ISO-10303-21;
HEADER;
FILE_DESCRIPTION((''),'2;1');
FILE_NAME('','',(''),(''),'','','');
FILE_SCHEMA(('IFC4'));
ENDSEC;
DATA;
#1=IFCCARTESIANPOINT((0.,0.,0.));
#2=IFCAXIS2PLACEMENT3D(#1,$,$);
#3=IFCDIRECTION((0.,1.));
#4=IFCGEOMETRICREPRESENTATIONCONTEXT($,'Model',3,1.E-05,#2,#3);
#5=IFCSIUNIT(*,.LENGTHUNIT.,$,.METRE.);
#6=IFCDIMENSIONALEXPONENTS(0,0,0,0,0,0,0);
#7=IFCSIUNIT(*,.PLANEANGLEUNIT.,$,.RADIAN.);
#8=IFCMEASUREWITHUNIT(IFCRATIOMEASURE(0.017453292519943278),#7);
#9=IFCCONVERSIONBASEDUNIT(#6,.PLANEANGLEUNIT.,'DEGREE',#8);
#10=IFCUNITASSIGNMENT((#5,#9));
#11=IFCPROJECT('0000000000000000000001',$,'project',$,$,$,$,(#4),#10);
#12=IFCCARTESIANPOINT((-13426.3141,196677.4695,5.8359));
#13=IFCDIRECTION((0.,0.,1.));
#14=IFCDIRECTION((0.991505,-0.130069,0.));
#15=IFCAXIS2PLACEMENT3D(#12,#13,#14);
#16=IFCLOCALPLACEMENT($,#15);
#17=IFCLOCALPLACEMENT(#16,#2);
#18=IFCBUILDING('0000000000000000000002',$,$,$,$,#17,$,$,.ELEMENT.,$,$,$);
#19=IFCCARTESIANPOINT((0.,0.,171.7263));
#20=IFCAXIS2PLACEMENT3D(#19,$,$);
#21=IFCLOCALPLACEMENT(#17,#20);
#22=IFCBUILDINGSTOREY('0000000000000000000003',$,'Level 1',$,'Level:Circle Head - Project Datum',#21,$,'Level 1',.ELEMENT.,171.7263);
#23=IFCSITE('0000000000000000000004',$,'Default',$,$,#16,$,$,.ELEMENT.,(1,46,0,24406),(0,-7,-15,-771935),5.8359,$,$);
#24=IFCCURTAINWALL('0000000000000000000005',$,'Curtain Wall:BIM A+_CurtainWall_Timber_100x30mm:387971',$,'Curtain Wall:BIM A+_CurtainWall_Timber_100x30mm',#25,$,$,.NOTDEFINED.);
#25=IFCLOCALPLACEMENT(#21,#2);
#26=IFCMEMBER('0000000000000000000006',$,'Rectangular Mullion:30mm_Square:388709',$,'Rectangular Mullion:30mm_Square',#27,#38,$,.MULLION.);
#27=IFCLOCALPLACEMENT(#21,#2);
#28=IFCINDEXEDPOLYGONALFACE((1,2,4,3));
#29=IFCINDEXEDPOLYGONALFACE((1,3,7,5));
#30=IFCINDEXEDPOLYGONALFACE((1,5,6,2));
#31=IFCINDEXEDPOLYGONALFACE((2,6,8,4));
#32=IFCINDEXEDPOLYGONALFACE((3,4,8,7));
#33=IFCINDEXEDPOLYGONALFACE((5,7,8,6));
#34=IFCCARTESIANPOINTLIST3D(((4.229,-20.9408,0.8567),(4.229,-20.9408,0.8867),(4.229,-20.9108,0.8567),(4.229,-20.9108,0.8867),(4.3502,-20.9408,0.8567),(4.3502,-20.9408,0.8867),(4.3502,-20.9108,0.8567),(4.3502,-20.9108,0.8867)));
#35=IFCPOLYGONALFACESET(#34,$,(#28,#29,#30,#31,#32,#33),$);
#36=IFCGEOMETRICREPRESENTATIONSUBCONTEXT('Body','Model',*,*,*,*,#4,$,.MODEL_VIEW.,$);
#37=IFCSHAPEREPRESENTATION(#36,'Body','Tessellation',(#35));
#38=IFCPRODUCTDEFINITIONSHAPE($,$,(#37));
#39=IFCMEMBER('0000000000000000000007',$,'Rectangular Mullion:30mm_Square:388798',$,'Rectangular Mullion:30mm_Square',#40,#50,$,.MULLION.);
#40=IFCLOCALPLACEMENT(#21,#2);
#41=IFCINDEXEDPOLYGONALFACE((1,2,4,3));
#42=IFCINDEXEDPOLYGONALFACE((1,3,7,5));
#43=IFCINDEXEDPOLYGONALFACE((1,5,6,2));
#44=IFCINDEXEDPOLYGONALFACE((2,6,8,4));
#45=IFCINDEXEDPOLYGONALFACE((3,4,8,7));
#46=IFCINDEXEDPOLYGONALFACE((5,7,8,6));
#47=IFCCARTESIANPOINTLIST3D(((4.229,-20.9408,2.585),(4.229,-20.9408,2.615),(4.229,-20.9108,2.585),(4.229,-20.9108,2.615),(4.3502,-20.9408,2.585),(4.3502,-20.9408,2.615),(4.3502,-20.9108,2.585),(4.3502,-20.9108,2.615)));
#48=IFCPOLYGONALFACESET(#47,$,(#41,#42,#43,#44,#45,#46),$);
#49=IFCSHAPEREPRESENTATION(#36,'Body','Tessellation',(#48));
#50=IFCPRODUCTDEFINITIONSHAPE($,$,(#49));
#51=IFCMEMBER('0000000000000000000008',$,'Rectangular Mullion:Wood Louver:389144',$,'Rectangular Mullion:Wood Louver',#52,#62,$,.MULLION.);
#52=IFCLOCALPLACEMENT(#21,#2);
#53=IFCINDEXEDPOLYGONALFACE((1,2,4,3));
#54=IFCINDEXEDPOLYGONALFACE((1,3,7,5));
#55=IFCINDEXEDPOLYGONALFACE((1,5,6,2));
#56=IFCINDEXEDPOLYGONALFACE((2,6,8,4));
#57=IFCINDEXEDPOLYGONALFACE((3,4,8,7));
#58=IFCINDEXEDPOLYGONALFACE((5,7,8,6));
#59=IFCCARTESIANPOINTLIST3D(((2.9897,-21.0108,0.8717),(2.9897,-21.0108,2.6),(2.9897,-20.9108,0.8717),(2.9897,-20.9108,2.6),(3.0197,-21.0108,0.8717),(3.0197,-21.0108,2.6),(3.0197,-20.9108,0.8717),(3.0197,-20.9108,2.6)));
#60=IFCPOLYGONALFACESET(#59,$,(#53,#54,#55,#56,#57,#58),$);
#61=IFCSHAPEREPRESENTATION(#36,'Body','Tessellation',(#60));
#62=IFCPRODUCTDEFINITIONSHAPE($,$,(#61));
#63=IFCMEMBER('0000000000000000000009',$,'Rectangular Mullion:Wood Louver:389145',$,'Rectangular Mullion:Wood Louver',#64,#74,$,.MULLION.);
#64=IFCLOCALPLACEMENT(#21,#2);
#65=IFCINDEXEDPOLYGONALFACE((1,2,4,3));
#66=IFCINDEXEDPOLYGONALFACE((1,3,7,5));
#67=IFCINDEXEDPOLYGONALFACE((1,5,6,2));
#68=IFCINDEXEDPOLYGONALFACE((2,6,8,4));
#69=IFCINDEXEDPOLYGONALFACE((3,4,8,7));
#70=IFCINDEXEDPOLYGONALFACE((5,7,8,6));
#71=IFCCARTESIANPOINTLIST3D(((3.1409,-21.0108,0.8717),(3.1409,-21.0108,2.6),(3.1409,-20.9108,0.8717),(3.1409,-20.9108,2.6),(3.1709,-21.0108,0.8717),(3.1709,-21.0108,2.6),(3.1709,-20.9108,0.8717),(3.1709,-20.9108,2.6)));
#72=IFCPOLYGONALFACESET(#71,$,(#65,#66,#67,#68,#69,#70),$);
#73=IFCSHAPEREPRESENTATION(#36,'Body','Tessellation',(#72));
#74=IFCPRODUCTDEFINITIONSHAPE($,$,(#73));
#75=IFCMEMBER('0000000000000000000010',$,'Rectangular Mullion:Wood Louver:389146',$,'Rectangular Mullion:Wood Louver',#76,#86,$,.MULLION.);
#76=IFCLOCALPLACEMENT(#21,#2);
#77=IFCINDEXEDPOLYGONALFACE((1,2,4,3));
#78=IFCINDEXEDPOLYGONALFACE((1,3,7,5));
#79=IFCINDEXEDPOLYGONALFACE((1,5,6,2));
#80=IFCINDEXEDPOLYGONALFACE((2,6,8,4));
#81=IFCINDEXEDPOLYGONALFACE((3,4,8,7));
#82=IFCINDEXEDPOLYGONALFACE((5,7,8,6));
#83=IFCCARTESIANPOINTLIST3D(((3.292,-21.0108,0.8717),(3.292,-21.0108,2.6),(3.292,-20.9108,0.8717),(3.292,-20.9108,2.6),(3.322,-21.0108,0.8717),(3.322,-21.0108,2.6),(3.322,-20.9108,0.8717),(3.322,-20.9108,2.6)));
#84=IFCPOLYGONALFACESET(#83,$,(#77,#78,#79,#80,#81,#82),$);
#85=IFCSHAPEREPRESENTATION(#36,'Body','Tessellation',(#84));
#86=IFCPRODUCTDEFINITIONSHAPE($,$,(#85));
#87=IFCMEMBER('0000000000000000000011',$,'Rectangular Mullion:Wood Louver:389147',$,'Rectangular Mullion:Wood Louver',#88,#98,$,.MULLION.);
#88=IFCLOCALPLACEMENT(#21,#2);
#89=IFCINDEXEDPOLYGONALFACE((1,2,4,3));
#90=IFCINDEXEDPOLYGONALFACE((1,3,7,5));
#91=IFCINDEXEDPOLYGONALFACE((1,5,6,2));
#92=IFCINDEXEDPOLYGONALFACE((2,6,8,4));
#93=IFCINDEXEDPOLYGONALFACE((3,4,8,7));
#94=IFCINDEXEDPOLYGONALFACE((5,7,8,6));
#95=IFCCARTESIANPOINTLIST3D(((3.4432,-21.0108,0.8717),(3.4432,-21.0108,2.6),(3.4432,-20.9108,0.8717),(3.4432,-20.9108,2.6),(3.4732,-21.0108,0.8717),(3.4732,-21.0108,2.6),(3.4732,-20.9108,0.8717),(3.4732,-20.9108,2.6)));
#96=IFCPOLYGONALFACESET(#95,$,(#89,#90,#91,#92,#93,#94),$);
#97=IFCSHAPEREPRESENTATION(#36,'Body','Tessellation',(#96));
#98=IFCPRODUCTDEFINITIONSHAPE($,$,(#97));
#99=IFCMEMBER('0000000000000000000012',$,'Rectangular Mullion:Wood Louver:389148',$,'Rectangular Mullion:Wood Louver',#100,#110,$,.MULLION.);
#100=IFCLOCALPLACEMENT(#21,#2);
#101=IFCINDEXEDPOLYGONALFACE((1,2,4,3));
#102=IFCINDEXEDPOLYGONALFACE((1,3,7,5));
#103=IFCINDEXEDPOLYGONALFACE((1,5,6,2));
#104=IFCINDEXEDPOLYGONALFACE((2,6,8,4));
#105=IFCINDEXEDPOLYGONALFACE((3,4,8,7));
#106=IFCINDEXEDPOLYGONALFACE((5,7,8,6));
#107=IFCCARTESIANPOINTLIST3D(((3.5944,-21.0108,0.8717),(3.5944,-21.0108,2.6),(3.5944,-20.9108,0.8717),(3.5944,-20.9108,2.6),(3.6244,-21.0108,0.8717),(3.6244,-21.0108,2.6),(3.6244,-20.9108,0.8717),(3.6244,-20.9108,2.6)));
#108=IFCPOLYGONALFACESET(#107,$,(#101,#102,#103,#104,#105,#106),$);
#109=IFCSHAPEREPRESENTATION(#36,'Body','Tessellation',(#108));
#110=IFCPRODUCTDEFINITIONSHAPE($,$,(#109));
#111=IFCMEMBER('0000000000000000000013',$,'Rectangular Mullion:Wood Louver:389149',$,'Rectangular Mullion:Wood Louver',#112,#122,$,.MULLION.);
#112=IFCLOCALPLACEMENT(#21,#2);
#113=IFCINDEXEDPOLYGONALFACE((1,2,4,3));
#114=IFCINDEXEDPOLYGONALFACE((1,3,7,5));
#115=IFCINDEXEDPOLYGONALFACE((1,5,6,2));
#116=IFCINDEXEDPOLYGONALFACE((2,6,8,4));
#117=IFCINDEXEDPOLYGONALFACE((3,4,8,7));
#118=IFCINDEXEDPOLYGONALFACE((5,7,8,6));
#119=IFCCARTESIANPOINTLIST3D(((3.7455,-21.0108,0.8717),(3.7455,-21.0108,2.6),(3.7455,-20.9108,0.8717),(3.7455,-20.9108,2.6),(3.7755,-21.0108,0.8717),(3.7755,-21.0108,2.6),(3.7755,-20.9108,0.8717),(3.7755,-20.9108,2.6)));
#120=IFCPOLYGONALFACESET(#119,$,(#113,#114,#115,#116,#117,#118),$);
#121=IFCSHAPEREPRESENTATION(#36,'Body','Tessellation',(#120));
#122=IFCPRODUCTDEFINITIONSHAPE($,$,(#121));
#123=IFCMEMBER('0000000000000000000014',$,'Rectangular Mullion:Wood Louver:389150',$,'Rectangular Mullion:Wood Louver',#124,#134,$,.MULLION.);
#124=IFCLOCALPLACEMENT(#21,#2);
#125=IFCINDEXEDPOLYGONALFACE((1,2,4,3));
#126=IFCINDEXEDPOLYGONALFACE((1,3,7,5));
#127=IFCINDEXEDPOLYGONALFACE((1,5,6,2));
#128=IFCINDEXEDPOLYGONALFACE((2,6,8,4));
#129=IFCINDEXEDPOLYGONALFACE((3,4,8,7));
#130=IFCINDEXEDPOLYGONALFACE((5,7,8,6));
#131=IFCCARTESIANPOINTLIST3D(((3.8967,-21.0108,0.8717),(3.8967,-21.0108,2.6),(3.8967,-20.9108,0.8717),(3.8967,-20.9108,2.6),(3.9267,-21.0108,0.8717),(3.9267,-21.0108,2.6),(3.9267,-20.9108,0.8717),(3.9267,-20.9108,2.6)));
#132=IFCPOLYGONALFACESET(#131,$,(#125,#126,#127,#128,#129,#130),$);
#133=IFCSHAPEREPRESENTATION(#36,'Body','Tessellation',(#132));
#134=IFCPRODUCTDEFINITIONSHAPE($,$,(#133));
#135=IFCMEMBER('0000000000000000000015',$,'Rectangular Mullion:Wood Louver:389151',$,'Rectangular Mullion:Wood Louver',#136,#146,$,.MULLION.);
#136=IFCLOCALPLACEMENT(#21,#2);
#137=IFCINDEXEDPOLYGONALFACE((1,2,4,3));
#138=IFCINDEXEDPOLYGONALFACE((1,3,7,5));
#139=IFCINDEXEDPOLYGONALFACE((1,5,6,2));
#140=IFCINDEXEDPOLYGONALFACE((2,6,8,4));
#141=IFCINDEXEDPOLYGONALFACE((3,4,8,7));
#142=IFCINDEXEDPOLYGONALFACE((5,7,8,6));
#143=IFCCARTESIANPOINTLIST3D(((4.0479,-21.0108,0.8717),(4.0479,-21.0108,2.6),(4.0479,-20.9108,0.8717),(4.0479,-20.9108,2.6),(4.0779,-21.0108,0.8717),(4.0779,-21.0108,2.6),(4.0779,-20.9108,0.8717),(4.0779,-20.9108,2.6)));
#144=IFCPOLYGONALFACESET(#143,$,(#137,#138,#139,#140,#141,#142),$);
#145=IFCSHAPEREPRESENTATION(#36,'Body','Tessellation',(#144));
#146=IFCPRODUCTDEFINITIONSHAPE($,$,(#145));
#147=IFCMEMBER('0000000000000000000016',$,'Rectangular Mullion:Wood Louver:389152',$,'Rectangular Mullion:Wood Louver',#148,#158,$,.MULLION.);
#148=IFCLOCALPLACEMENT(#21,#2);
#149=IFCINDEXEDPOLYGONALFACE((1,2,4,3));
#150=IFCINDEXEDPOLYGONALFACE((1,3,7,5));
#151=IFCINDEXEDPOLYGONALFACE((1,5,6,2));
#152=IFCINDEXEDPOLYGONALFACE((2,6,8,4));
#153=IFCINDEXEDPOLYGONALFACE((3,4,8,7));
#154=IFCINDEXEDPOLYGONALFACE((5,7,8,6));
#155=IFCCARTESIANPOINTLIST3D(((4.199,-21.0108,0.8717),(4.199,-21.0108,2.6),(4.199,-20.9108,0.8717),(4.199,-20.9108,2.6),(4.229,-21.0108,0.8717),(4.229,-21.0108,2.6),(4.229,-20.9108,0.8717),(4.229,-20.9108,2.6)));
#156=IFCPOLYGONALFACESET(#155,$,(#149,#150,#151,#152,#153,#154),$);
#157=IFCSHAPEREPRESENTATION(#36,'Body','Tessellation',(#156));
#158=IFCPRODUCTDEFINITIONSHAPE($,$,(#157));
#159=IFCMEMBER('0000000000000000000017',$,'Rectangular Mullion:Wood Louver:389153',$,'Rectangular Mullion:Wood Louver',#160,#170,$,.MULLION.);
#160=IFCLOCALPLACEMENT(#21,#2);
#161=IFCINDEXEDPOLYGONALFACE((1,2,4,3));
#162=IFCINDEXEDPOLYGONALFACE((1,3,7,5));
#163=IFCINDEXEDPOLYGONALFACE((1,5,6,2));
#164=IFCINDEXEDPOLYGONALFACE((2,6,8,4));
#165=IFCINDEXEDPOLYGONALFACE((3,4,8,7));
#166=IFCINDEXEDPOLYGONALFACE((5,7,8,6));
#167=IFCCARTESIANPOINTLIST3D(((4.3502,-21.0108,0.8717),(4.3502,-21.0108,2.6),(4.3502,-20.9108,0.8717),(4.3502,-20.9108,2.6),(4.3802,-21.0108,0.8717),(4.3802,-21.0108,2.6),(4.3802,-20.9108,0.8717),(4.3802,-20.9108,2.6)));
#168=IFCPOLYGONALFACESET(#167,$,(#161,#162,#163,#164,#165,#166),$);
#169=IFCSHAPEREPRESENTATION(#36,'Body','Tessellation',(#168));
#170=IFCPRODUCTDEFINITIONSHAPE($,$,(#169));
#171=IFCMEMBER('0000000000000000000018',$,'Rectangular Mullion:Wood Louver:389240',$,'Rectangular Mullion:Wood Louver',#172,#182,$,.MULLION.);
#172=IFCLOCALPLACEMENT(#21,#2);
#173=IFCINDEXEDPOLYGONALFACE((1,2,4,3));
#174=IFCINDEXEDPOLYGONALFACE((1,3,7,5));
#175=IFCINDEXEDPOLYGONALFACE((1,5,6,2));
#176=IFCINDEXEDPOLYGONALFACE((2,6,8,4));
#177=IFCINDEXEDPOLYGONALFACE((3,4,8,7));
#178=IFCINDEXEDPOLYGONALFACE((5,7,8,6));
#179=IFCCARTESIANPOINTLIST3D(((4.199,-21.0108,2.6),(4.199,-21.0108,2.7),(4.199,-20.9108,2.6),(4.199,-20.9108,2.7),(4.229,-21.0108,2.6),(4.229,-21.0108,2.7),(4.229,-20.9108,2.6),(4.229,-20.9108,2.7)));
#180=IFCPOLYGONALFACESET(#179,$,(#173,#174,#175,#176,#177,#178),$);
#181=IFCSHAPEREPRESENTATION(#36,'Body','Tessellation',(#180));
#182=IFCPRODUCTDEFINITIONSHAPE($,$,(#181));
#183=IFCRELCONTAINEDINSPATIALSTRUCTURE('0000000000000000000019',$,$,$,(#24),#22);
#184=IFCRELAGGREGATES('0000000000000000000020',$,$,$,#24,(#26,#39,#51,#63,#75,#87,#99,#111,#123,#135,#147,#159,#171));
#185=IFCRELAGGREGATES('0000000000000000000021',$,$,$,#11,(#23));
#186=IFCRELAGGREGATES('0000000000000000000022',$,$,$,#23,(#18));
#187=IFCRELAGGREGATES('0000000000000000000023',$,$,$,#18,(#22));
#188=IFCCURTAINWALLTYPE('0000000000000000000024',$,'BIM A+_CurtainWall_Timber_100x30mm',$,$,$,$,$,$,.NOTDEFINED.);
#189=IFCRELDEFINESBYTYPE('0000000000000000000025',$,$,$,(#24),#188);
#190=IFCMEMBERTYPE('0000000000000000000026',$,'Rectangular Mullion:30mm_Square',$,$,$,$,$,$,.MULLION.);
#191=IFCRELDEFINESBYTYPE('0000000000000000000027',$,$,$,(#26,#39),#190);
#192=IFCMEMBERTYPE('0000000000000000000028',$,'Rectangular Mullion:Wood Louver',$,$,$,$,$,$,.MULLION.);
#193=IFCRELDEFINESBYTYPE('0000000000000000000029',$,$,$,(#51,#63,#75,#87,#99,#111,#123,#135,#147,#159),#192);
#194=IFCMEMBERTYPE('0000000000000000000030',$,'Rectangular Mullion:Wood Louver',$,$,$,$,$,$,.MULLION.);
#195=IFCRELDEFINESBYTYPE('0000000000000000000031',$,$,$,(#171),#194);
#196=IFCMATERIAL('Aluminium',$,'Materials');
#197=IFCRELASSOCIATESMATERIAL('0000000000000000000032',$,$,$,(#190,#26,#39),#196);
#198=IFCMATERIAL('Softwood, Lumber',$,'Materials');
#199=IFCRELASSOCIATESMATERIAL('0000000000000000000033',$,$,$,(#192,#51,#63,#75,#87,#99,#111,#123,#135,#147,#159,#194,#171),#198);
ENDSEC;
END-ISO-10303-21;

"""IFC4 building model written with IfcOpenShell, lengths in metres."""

from ifc_helpers import new_model, entity, si_unit, converted_unit, direction, frame, origin, place, context, subcontext, project, spatial, indexed_curve, outline, extrude, source, transform, mapped, material, type_object, type_shapes, element, aggregate, save


model = new_model("IFC4")

# Units and contexts
model_context = context("Model", 3, precision=1e-05, world=origin(), true_north=direction((0.0, 1.0)))
body_context = subcontext(model_context, "Body", "Model", "MODEL_VIEW")
ifc_project = project(units=[si_unit("LENGTHUNIT", "METRE"), converted_unit("PLANEANGLEUNIT", "DEGREE", entity("IfcRatioMeasure", 0.017453292519943278), si_unit("PLANEANGLEUNIT", "RADIAN"), dimensions=[0, 0, 0, 0, 0, 0, 0])], contexts=[model_context])

# Site, building, storey
site_placement = place(None, frame((-13426.3141, 196677.4695, 5.8359), z_axis=(0.0, 0.0, 1.0), x_axis=(0.991505, -0.130069, 0.0)))
site = spatial("IfcSite", under=ifc_project, at=site_placement, Name="Default", CompositionType="ELEMENT", RefLatitude=(1, 46, 0, 24406), RefLongitude=(0, -7, -15, -771935), RefElevation=5.8359)
building_placement = place(site_placement, origin())
building = spatial("IfcBuilding", under=site, at=building_placement, CompositionType="ELEMENT")
storey_placement = place(building_placement, frame((0.0, 0.0, 171.7263)))
storey = spatial("IfcBuildingStorey", under=building, at=storey_placement, Name="Level 1", ObjectType="Level:Circle Head - Project Datum", LongName="Level 1", CompositionType="ELEMENT", Elevation=171.7263)

# Curtain wall, members
ifc_material_1 = material(Name="Aluminium", Category="Materials")
curtain_wall_type_1 = type_object("IfcCurtainWallType", Name="BIM A+_CurtainWall_Timber_100x30mm", PredefinedType="NOTDEFINED")
curtain_wall_1_placement = place(storey_placement, frame((0.0, 0.0, -171.7263)))
curtain_wall_1 = element("IfcCurtainWall", 1, at=curtain_wall_1_placement, inside=storey, type_object=curtain_wall_type_1, Name="Curtain Wall:BIM A+_CurtainWall_Timber_100x30mm:387971", ObjectType="Curtain Wall:BIM A+_CurtainWall_Timber_100x30mm", PredefinedType="NOTDEFINED")
ifc_material_2 = material(Name="Softwood, Lumber", Category="Materials")
member_type_1 = type_object("IfcMemberType", Name="Rectangular Mullion:30mm_Square", PredefinedType="MULLION", material=ifc_material_1)
shared_shape_1 = source(origin(), body_context, "Body", "SweptSolid", [
    extrude(outline(indexed_curve([(-0.015, -0.015), (0.015, -0.015), (0.015, 0.015), (-0.015, 0.015), (-0.015, -0.015)], self_intersect=False)), frame((0.0, 0.0, -0.1212), z_axis=(0.0, 0.0, 1.0), x_axis=(0.0, -1.0, 0.0)), (0.0, 0.0, 1.0), 0.1212),
])
type_shapes(member_type_1, [shared_shape_1])
member_1_placement = place(curtain_wall_1_placement, frame((4.3502, -20.9258, 172.598), z_axis=(1.0, 0.0, 0.0), x_axis=(0.0, 0.0, 1.0)))
member_1 = element("IfcMember", 2, at=member_1_placement, type_object=member_type_1, material=ifc_material_1, Name="Rectangular Mullion:30mm_Square:388709", ObjectType="Rectangular Mullion:30mm_Square", PredefinedType="MULLION", context=body_context, shape_type="MappedRepresentation", body=[
    mapped(shared_shape_1, transform((0.0, 0.0, 0.0), scale=1.0)),
])
member_2_placement = place(curtain_wall_1_placement, frame((4.3502, -20.9258, 174.3263), z_axis=(1.0, 0.0, 0.0), x_axis=(0.0, 0.0, 1.0)))
member_2 = element("IfcMember", 3, at=member_2_placement, type_object=member_type_1, material=ifc_material_1, Name="Rectangular Mullion:30mm_Square:388798", ObjectType="Rectangular Mullion:30mm_Square", PredefinedType="MULLION", context=body_context, shape_type="MappedRepresentation", body=[
    mapped(shared_shape_1, transform((0.0, 0.0, 0.0), scale=1.0)),
])
member_type_2 = type_object("IfcMemberType", Name="Rectangular Mullion:Wood Louver", PredefinedType="MULLION", material=ifc_material_2)
shared_shape_2 = source(origin(), body_context, "Body", "SweptSolid", [
    extrude(outline(indexed_curve([(-0.05, -0.015), (0.05, -0.015), (0.05, 0.015), (-0.05, 0.015), (-0.05, -0.015)], self_intersect=False)), frame((0.0, 0.035, -1.7283), z_axis=(0.0, 0.0, 1.0), x_axis=(0.0, -1.0, 0.0)), (0.0, 0.0, 1.0), 1.7283),
])
type_shapes(member_type_2, [shared_shape_2])
member_3_placement = place(curtain_wall_1_placement, frame((3.0047, -20.9258, 172.598), z_axis=(0.0, 0.0, -1.0), x_axis=(1.0, 0.0, 0.0)))
member_3 = element("IfcMember", 4, at=member_3_placement, type_object=member_type_2, material=ifc_material_2, Name="Rectangular Mullion:Wood Louver:389144", ObjectType="Rectangular Mullion:Wood Louver", PredefinedType="MULLION", context=body_context, shape_type="MappedRepresentation", body=[
    mapped(shared_shape_2, transform((0.0, 0.0, 0.0), scale=1.0)),
])
member_4_placement = place(curtain_wall_1_placement, frame((3.1559, -20.9258, 172.598), z_axis=(0.0, 0.0, -1.0), x_axis=(1.0, 0.0, 0.0)))
member_4 = element("IfcMember", 5, at=member_4_placement, type_object=member_type_2, material=ifc_material_2, Name="Rectangular Mullion:Wood Louver:389145", ObjectType="Rectangular Mullion:Wood Louver", PredefinedType="MULLION", context=body_context, shape_type="MappedRepresentation", body=[
    mapped(shared_shape_2, transform((0.0, 0.0, 0.0), scale=1.0)),
])
member_5_placement = place(curtain_wall_1_placement, frame((3.307, -20.9258, 172.598), z_axis=(0.0, 0.0, -1.0), x_axis=(1.0, 0.0, 0.0)))
member_5 = element("IfcMember", 6, at=member_5_placement, type_object=member_type_2, material=ifc_material_2, Name="Rectangular Mullion:Wood Louver:389146", ObjectType="Rectangular Mullion:Wood Louver", PredefinedType="MULLION", context=body_context, shape_type="MappedRepresentation", body=[
    mapped(shared_shape_2, transform((0.0, 0.0, 0.0), scale=1.0)),
])
member_6_placement = place(curtain_wall_1_placement, frame((3.4582, -20.9258, 172.598), z_axis=(0.0, 0.0, -1.0), x_axis=(1.0, 0.0, 0.0)))
member_6 = element("IfcMember", 7, at=member_6_placement, type_object=member_type_2, material=ifc_material_2, Name="Rectangular Mullion:Wood Louver:389147", ObjectType="Rectangular Mullion:Wood Louver", PredefinedType="MULLION", context=body_context, shape_type="MappedRepresentation", body=[
    mapped(shared_shape_2, transform((0.0, 0.0, 0.0), scale=1.0)),
])
member_7_placement = place(curtain_wall_1_placement, frame((3.6094, -20.9258, 172.598), z_axis=(0.0, 0.0, -1.0), x_axis=(1.0, 0.0, 0.0)))
member_7 = element("IfcMember", 8, at=member_7_placement, type_object=member_type_2, material=ifc_material_2, Name="Rectangular Mullion:Wood Louver:389148", ObjectType="Rectangular Mullion:Wood Louver", PredefinedType="MULLION", context=body_context, shape_type="MappedRepresentation", body=[
    mapped(shared_shape_2, transform((0.0, 0.0, 0.0), scale=1.0)),
])
member_8_placement = place(curtain_wall_1_placement, frame((3.7605, -20.9258, 172.598), z_axis=(0.0, 0.0, -1.0), x_axis=(1.0, 0.0, 0.0)))
member_8 = element("IfcMember", 9, at=member_8_placement, type_object=member_type_2, material=ifc_material_2, Name="Rectangular Mullion:Wood Louver:389149", ObjectType="Rectangular Mullion:Wood Louver", PredefinedType="MULLION", context=body_context, shape_type="MappedRepresentation", body=[
    mapped(shared_shape_2, transform((0.0, 0.0, 0.0), scale=1.0)),
])
member_9_placement = place(curtain_wall_1_placement, frame((3.9117, -20.9258, 172.598), z_axis=(0.0, 0.0, -1.0), x_axis=(1.0, 0.0, 0.0)))
member_9 = element("IfcMember", 10, at=member_9_placement, type_object=member_type_2, material=ifc_material_2, Name="Rectangular Mullion:Wood Louver:389150", ObjectType="Rectangular Mullion:Wood Louver", PredefinedType="MULLION", context=body_context, shape_type="MappedRepresentation", body=[
    mapped(shared_shape_2, transform((0.0, 0.0, 0.0), scale=1.0)),
])
member_10_placement = place(curtain_wall_1_placement, frame((4.0629, -20.9258, 172.598), z_axis=(0.0, 0.0, -1.0), x_axis=(1.0, 0.0, 0.0)))
member_10 = element("IfcMember", 11, at=member_10_placement, type_object=member_type_2, material=ifc_material_2, Name="Rectangular Mullion:Wood Louver:389151", ObjectType="Rectangular Mullion:Wood Louver", PredefinedType="MULLION", context=body_context, shape_type="MappedRepresentation", body=[
    mapped(shared_shape_2, transform((0.0, 0.0, 0.0), scale=1.0)),
])
member_11_placement = place(curtain_wall_1_placement, frame((4.214, -20.9258, 172.598), z_axis=(0.0, 0.0, -1.0), x_axis=(1.0, 0.0, 0.0)))
member_11 = element("IfcMember", 12, at=member_11_placement, type_object=member_type_2, material=ifc_material_2, Name="Rectangular Mullion:Wood Louver:389152", ObjectType="Rectangular Mullion:Wood Louver", PredefinedType="MULLION", context=body_context, shape_type="MappedRepresentation", body=[
    mapped(shared_shape_2, transform((0.0, 0.0, 0.0), scale=1.0)),
])
member_12_placement = place(curtain_wall_1_placement, frame((4.3652, -20.9258, 172.598), z_axis=(0.0, 0.0, -1.0), x_axis=(1.0, 0.0, 0.0)))
member_12 = element("IfcMember", 13, at=member_12_placement, type_object=member_type_2, material=ifc_material_2, Name="Rectangular Mullion:Wood Louver:389153", ObjectType="Rectangular Mullion:Wood Louver", PredefinedType="MULLION", context=body_context, shape_type="MappedRepresentation", body=[
    mapped(shared_shape_2, transform((0.0, 0.0, 0.0), scale=1.0)),
])
member_type_3 = type_object("IfcMemberType", Name="Rectangular Mullion:Wood Louver", PredefinedType="MULLION", material=ifc_material_2)
shared_shape_3 = source(origin(), body_context, "Body", "SweptSolid", [
    extrude(outline(indexed_curve([(-0.05, -0.015), (0.05, -0.015), (0.05, 0.015), (-0.05, 0.015), (-0.05, -0.015)], self_intersect=False)), frame((0.0, 0.035, -0.1), z_axis=(0.0, 0.0, 1.0), x_axis=(0.0, -1.0, 0.0)), (0.0, 0.0, 1.0), 0.1),
])
type_shapes(member_type_3, [shared_shape_3])
member_13_placement = place(curtain_wall_1_placement, frame((4.214, -20.9258, 174.3263), z_axis=(0.0, 0.0, -1.0), x_axis=(1.0, 0.0, 0.0)))
member_13 = element("IfcMember", 14, at=member_13_placement, type_object=member_type_3, material=ifc_material_2, Name="Rectangular Mullion:Wood Louver:389240", ObjectType="Rectangular Mullion:Wood Louver", PredefinedType="MULLION", context=body_context, shape_type="MappedRepresentation", body=[
    mapped(shared_shape_3, transform((0.0, 0.0, 0.0), scale=1.0)),
])

aggregate(curtain_wall_1, [member_1, member_2, member_3, member_4, member_5, member_6, member_7, member_8, member_9, member_10, member_11, member_12, member_13])

save(model, "model.ifc")
